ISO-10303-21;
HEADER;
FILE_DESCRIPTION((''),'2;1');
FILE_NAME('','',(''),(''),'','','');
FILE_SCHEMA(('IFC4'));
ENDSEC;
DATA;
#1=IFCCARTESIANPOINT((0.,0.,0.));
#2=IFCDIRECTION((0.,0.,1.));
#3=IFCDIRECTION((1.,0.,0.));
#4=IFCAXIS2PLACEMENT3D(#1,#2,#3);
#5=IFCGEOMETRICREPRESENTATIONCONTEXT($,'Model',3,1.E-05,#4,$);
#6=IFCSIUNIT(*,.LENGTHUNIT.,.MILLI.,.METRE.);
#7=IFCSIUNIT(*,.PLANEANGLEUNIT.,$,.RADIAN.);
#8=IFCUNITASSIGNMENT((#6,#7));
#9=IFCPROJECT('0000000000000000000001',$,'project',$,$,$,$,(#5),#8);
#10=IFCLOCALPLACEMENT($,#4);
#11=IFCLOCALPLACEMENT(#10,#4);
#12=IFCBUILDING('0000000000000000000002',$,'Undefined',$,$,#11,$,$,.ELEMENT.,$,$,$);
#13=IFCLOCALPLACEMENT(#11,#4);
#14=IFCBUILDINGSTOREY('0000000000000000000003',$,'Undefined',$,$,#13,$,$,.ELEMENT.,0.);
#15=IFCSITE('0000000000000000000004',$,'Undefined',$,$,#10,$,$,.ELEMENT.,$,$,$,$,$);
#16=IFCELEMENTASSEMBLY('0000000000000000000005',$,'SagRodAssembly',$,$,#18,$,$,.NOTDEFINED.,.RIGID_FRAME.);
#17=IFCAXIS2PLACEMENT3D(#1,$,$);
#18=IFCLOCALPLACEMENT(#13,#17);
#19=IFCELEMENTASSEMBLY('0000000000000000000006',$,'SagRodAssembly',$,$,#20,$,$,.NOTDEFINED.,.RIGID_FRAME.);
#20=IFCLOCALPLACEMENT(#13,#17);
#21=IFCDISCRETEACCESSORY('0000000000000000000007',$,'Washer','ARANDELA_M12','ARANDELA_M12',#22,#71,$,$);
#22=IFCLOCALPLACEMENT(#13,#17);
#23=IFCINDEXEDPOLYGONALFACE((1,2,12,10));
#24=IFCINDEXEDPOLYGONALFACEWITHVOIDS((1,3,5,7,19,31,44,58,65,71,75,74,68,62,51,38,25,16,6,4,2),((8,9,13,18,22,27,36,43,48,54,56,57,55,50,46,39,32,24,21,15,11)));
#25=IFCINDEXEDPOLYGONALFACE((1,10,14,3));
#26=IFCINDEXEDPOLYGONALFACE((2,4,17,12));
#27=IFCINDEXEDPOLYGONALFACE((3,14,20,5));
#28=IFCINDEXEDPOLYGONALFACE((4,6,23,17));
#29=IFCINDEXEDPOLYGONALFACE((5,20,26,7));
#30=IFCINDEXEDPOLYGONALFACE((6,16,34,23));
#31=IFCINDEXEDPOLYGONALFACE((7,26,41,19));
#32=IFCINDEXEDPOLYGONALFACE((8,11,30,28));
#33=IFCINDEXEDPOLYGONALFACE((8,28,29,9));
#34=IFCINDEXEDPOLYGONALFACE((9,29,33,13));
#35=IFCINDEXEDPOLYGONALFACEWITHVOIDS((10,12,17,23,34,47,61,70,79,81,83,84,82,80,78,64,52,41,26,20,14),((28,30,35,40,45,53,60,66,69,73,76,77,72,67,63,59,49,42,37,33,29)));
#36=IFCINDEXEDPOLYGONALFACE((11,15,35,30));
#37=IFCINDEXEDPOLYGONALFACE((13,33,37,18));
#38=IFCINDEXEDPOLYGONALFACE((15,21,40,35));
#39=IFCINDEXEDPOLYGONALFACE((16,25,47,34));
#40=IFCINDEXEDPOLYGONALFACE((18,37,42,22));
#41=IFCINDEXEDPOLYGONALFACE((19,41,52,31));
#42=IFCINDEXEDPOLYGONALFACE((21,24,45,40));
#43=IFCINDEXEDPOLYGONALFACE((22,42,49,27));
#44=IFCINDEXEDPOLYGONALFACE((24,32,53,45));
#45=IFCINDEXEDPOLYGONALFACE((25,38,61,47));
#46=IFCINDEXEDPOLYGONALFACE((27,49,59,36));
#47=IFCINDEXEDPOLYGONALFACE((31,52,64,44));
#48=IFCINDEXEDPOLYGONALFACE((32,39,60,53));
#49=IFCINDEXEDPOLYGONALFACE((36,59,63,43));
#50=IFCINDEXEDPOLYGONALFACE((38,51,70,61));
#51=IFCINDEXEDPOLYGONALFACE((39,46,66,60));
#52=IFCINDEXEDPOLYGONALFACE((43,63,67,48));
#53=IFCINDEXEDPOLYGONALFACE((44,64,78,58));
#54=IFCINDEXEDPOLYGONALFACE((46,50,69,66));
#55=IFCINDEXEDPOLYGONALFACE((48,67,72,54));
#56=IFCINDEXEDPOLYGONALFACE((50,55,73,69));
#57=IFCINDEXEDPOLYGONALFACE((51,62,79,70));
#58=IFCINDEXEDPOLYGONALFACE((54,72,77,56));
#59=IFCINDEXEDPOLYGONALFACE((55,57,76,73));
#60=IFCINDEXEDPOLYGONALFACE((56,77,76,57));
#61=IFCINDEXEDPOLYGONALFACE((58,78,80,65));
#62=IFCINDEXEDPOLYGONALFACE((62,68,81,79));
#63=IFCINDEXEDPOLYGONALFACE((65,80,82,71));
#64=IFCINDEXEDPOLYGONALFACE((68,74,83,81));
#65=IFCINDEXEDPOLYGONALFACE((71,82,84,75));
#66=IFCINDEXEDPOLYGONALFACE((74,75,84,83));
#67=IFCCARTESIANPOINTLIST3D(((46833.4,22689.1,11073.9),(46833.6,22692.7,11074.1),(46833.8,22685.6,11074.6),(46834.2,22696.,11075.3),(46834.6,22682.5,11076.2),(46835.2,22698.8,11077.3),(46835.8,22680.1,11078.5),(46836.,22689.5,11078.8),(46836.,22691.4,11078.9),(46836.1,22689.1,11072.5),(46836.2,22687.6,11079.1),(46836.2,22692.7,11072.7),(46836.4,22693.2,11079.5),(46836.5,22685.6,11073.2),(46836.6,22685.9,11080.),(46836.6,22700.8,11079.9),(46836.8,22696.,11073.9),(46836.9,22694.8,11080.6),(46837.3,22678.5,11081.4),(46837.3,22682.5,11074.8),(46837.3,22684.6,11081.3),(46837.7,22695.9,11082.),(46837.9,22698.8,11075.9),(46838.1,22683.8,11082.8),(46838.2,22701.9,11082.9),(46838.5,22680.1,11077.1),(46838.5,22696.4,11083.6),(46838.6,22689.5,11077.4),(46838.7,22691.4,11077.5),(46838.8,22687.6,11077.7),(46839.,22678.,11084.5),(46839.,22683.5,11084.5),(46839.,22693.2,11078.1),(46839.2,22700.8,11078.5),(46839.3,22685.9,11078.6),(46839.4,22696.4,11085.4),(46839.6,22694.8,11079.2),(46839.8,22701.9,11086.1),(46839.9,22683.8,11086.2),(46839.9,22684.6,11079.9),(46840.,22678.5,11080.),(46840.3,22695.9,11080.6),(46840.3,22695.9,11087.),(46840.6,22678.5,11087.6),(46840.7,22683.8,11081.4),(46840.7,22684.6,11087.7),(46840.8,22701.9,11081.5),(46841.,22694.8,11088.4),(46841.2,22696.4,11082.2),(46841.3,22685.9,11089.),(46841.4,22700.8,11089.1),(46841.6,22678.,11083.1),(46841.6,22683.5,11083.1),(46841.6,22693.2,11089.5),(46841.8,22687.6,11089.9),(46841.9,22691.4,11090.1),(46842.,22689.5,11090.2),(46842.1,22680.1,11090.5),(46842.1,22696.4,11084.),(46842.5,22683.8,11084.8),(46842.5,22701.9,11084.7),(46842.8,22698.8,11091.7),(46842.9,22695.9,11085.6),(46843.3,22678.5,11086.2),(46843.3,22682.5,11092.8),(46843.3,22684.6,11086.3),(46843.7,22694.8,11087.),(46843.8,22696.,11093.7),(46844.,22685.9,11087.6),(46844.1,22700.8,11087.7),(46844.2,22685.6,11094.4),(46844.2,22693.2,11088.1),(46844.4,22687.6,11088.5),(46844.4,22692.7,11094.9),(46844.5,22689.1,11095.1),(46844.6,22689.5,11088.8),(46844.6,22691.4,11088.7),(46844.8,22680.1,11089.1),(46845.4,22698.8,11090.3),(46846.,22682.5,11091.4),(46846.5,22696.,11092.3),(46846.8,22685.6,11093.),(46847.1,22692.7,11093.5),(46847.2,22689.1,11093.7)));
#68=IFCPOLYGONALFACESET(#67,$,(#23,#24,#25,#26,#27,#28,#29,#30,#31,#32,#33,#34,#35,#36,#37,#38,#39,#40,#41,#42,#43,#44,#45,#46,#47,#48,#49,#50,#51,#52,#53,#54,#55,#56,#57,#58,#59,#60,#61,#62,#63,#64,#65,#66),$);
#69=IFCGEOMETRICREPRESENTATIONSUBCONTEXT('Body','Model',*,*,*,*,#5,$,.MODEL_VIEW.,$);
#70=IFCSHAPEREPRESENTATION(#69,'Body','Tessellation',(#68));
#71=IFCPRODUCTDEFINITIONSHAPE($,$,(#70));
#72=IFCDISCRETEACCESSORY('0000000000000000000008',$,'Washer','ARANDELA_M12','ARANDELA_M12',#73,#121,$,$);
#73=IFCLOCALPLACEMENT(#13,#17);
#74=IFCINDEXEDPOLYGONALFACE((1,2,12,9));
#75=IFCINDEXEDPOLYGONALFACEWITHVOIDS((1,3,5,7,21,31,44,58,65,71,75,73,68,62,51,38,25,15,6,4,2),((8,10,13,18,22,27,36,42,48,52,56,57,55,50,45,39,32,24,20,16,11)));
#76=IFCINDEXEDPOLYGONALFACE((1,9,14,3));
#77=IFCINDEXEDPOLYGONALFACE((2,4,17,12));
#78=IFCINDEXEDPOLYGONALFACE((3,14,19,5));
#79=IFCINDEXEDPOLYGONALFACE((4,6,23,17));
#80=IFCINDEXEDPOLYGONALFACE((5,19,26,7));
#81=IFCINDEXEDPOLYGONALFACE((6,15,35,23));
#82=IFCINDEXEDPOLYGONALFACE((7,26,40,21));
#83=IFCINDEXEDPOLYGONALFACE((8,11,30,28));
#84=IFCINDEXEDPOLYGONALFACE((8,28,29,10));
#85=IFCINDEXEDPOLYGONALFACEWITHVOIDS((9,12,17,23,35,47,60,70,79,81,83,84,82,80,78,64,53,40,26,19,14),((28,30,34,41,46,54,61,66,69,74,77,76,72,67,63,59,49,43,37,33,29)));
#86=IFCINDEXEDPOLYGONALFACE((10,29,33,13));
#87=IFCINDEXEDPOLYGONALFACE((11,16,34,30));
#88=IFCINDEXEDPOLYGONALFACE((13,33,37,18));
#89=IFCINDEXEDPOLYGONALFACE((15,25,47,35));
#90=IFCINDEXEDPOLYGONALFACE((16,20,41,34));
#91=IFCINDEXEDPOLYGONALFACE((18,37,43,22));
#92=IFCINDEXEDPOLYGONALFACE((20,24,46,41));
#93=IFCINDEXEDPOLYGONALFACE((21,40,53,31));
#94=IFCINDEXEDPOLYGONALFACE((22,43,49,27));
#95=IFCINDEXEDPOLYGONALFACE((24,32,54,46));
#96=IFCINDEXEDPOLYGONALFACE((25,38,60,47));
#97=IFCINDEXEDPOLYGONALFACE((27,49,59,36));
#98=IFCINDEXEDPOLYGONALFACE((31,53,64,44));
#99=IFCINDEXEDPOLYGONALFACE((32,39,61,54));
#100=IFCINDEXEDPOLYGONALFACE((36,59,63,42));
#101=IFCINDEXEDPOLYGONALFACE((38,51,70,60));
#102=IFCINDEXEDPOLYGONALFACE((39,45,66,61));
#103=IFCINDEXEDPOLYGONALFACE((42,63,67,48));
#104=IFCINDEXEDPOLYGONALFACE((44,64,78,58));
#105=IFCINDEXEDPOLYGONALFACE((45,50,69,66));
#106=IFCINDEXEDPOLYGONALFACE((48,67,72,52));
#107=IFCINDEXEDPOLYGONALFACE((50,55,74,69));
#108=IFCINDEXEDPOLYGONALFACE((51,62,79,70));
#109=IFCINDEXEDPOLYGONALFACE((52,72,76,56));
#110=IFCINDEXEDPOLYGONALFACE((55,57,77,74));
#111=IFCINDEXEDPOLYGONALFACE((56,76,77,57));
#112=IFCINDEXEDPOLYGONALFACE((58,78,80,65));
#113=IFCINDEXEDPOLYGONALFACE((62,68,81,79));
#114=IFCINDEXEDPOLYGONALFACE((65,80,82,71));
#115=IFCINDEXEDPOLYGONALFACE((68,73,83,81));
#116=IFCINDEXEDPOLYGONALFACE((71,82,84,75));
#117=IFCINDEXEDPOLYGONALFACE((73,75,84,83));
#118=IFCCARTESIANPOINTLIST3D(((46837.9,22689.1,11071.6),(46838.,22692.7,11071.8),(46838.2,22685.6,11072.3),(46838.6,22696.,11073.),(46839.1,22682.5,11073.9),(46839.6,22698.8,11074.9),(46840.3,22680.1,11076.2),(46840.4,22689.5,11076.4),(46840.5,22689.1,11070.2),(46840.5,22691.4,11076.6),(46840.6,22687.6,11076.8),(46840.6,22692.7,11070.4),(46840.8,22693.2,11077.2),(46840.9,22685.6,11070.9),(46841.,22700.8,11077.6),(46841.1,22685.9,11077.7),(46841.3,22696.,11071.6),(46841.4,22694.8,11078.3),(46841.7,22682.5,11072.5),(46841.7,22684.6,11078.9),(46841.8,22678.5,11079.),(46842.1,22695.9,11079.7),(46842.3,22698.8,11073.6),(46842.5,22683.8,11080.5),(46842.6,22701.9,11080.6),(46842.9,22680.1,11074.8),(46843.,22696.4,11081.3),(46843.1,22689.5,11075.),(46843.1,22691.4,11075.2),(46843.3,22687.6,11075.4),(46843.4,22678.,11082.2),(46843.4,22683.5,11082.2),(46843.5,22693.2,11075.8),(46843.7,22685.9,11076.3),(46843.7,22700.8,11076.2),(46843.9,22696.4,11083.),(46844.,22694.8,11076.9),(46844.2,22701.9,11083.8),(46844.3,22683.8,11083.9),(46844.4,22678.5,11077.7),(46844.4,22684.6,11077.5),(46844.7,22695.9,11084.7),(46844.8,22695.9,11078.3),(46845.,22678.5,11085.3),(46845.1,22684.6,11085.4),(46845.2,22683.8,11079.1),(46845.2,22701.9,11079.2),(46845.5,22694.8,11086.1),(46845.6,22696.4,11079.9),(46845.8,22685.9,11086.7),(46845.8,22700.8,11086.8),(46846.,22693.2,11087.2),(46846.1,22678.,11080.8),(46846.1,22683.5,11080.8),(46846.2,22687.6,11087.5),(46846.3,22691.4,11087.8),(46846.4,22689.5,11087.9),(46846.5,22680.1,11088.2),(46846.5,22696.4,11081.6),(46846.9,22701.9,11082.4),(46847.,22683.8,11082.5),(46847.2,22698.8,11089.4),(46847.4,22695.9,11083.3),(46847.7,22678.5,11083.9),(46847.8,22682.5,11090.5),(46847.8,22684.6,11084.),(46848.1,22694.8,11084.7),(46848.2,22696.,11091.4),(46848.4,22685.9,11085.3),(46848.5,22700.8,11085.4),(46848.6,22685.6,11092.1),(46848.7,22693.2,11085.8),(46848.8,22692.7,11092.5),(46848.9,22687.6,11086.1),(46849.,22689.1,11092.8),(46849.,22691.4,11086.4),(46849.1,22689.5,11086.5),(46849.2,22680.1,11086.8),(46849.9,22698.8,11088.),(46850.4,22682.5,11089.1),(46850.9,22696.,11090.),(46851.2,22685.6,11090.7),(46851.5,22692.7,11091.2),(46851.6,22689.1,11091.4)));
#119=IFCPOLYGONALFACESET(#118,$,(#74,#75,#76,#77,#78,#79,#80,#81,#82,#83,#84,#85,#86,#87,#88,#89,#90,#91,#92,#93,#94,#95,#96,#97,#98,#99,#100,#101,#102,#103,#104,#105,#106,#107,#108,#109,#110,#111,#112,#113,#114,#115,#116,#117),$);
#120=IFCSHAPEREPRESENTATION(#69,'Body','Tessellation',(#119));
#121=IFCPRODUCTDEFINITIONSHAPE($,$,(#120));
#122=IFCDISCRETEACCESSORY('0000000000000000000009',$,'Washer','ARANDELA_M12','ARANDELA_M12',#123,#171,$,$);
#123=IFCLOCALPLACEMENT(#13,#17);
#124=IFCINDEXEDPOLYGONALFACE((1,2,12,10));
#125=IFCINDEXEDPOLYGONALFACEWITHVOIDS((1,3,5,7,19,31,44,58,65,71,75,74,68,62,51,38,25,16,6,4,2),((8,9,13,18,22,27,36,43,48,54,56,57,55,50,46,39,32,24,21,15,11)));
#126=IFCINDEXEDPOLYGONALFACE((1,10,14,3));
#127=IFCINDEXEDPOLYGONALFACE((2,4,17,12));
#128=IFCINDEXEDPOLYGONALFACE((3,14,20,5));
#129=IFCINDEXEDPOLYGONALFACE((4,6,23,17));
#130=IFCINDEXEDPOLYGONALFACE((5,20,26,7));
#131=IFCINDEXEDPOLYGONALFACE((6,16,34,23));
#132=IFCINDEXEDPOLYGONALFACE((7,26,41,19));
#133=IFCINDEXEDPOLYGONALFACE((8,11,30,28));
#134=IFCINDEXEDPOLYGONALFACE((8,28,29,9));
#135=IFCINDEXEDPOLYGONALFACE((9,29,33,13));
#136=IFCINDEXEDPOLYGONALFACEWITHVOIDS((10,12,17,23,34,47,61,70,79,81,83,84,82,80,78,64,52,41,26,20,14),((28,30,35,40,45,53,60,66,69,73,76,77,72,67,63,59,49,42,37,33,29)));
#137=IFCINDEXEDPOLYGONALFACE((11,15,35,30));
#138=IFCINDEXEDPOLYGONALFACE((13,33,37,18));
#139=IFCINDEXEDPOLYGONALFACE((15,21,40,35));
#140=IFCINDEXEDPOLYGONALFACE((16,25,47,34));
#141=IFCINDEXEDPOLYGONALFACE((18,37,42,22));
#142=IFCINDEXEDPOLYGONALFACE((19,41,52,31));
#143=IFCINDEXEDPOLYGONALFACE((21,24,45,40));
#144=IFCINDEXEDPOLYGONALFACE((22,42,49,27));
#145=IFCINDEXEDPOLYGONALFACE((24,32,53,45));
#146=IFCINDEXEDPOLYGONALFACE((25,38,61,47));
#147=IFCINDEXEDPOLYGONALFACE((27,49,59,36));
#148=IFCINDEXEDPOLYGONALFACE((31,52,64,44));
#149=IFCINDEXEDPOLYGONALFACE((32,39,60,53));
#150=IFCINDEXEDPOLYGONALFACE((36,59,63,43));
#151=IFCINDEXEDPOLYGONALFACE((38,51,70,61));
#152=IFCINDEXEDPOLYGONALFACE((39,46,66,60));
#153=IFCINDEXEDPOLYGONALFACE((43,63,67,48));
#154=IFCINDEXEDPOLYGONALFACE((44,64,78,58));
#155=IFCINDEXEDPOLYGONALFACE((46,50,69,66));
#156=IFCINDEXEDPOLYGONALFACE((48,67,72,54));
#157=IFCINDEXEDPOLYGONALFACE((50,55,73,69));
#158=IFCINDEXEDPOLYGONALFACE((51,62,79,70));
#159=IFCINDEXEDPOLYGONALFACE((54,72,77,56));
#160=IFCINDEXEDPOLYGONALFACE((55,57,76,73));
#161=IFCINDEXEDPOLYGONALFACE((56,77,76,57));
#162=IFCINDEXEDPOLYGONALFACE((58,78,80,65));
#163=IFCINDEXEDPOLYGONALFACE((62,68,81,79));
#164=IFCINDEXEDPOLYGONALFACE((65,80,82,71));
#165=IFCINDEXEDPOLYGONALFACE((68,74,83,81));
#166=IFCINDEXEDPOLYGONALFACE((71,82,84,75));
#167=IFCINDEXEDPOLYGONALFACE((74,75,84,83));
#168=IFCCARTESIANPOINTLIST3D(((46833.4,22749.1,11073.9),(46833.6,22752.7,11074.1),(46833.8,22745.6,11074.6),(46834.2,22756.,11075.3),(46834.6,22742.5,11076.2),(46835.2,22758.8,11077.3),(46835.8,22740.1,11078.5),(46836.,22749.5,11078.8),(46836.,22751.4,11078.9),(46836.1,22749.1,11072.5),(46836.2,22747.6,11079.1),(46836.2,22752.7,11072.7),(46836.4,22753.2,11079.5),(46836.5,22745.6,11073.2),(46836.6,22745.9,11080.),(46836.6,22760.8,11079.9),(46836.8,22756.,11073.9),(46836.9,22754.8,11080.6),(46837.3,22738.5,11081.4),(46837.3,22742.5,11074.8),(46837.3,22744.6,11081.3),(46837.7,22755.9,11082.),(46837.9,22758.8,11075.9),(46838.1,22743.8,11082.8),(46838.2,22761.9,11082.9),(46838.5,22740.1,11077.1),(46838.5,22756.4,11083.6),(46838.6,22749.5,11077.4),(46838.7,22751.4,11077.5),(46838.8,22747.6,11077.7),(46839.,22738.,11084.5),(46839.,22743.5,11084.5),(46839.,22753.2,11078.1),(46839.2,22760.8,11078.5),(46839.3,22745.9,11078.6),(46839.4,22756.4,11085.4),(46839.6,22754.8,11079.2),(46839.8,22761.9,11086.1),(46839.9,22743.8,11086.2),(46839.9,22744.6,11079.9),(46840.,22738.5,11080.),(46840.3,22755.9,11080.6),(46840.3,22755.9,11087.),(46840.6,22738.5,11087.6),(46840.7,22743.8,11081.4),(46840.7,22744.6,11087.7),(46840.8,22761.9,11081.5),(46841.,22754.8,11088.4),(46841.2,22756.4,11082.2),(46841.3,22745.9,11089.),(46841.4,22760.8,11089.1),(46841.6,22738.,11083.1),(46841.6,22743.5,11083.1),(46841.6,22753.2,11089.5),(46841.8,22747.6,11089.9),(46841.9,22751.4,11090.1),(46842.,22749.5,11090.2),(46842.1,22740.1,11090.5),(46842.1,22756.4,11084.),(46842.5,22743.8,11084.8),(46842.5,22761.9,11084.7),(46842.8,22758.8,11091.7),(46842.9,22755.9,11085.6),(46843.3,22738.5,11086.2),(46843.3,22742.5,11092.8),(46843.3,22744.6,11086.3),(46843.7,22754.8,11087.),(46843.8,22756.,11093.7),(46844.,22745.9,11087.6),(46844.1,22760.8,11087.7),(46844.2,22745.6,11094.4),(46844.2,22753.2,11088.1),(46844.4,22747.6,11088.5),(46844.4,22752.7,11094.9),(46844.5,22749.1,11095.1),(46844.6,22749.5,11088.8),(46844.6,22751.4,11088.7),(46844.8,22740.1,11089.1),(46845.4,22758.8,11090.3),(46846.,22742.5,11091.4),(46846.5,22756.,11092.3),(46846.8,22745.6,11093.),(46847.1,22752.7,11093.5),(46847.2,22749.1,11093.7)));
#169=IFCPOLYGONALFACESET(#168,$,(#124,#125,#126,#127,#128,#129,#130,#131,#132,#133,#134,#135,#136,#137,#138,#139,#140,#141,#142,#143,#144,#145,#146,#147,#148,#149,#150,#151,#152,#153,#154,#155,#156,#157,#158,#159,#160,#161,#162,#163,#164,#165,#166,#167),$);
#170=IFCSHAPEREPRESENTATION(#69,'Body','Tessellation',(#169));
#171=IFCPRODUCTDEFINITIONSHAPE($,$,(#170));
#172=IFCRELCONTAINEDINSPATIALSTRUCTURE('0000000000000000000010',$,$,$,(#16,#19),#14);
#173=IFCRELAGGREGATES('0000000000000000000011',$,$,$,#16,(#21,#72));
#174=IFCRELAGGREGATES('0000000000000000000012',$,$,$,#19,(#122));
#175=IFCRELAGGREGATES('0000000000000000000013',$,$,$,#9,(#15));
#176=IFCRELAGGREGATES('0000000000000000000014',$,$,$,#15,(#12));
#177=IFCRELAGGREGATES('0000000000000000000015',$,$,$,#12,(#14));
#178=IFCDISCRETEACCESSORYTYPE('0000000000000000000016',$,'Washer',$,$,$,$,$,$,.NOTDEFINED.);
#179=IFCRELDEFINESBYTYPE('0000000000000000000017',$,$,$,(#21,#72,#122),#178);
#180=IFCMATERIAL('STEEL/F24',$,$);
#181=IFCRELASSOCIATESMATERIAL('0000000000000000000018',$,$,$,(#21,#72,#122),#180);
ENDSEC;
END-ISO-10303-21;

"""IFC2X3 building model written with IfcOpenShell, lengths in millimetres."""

from ifc_helpers import new_model, si_unit, frame, origin_with_axes, origin_2d_with_axis, place, context, subcontext, project, spatial, hollow_circle, extrude, material, type_object, element, aggregate, save


model = new_model("IFC2X3")

# Units and contexts
model_context = context("Model", 3, precision=1e-05, world=origin_with_axes())
body_context = subcontext(model_context, "Body", "Model", "MODEL_VIEW")
ifc_project = project(units=[si_unit("LENGTHUNIT", "METRE", prefix="MILLI"), si_unit("PLANEANGLEUNIT", "RADIAN")], contexts=[model_context])

# Site, building, storey
site_placement = place(None, origin_with_axes())
site = spatial("IfcSite", under=ifc_project, at=site_placement, Name="Undefined", CompositionType="ELEMENT")
building_placement = place(site_placement, origin_with_axes())
building = spatial("IfcBuilding", under=site, at=building_placement, Name="Undefined", CompositionType="ELEMENT")
storey_placement = place(building_placement, origin_with_axes())
storey = spatial("IfcBuildingStorey", under=building, at=storey_placement, Name="Undefined", CompositionType="ELEMENT", Elevation=0.0)

# Element assemblies
assembly_1_placement = place(storey_placement, origin_with_axes())
assembly_1 = element("IfcElementAssembly", 1, at=assembly_1_placement, inside=storey, Name="SagRodAssembly", AssemblyPlace="NOTDEFINED", PredefinedType="RIGID_FRAME")
ifc_material_1 = material(Name="STEEL/F24")
assembly_2_placement = place(storey_placement, origin_with_axes())
assembly_2 = element("IfcElementAssembly", 2, at=assembly_2_placement, inside=storey, Name="SagRodAssembly", AssemblyPlace="NOTDEFINED", PredefinedType="RIGID_FRAME")

# Discrete accessories
discrete_accessory_type_1 = type_object("IfcDiscreteAccessoryType", Name="Washer")
discrete_accessory_1_placement = place(assembly_1_placement, frame((46841.6, 22690.0, 11083.1), z_axis=(-0.463578, 0.0, -0.886056), x_axis=(-0.886056, 0.0, 0.463578)))
discrete_accessory_1 = element("IfcDiscreteAccessory", 3, at=discrete_accessory_1_placement, type_object=discrete_accessory_type_1, material=ifc_material_1, Name="Washer", Description="ARANDELA_M12", ObjectType="ARANDELA_M12", context=body_context, shape_type="SweptSolid", body=[
    extrude(hollow_circle(Radius=12.0, WallThickness=5.5, at=origin_2d_with_axis()), frame((3.0, 0.0, 0.0), z_axis=(-1.0, 0.0, 0.0), x_axis=(0.0, -1.0, 0.0)), (0.0, 0.0, 1.0), 3.0),
])
discrete_accessory_2_placement = place(assembly_1_placement, frame((46846.1, 22690.0, 11080.8), z_axis=(-0.463578, 0.0, -0.886056), x_axis=(-0.886056, 0.0, 0.463578)))
discrete_accessory_2 = element("IfcDiscreteAccessory", 4, at=discrete_accessory_2_placement, type_object=discrete_accessory_type_1, material=ifc_material_1, Name="Washer", Description="ARANDELA_M12", ObjectType="ARANDELA_M12", context=body_context, shape_type="SweptSolid", body=[
    extrude(hollow_circle(Radius=12.0, WallThickness=5.5, at=origin_2d_with_axis()), frame((3.0, 0.0, 0.0), z_axis=(-1.0, 0.0, 0.0), x_axis=(0.0, -1.0, 0.0)), (0.0, 0.0, 1.0), 3.0),
])
aggregate(assembly_1, [discrete_accessory_1, discrete_accessory_2])
discrete_accessory_3_placement = place(assembly_2_placement, frame((46841.6, 22750.0, 11083.1), z_axis=(-0.463578, 0.0, -0.886056), x_axis=(-0.886056, 0.0, 0.463578)))
discrete_accessory_3 = element("IfcDiscreteAccessory", 5, at=discrete_accessory_3_placement, type_object=discrete_accessory_type_1, material=ifc_material_1, Name="Washer", Description="ARANDELA_M12", ObjectType="ARANDELA_M12", context=body_context, shape_type="SweptSolid", body=[
    extrude(hollow_circle(Radius=12.0, WallThickness=5.5, at=origin_2d_with_axis()), frame((3.0, 0.0, 0.0), z_axis=(-1.0, 0.0, 0.0), x_axis=(0.0, -1.0, 0.0)), (0.0, 0.0, 1.0), 3.0),
])
aggregate(assembly_2, [discrete_accessory_3])

save(model, "model.ifc")
